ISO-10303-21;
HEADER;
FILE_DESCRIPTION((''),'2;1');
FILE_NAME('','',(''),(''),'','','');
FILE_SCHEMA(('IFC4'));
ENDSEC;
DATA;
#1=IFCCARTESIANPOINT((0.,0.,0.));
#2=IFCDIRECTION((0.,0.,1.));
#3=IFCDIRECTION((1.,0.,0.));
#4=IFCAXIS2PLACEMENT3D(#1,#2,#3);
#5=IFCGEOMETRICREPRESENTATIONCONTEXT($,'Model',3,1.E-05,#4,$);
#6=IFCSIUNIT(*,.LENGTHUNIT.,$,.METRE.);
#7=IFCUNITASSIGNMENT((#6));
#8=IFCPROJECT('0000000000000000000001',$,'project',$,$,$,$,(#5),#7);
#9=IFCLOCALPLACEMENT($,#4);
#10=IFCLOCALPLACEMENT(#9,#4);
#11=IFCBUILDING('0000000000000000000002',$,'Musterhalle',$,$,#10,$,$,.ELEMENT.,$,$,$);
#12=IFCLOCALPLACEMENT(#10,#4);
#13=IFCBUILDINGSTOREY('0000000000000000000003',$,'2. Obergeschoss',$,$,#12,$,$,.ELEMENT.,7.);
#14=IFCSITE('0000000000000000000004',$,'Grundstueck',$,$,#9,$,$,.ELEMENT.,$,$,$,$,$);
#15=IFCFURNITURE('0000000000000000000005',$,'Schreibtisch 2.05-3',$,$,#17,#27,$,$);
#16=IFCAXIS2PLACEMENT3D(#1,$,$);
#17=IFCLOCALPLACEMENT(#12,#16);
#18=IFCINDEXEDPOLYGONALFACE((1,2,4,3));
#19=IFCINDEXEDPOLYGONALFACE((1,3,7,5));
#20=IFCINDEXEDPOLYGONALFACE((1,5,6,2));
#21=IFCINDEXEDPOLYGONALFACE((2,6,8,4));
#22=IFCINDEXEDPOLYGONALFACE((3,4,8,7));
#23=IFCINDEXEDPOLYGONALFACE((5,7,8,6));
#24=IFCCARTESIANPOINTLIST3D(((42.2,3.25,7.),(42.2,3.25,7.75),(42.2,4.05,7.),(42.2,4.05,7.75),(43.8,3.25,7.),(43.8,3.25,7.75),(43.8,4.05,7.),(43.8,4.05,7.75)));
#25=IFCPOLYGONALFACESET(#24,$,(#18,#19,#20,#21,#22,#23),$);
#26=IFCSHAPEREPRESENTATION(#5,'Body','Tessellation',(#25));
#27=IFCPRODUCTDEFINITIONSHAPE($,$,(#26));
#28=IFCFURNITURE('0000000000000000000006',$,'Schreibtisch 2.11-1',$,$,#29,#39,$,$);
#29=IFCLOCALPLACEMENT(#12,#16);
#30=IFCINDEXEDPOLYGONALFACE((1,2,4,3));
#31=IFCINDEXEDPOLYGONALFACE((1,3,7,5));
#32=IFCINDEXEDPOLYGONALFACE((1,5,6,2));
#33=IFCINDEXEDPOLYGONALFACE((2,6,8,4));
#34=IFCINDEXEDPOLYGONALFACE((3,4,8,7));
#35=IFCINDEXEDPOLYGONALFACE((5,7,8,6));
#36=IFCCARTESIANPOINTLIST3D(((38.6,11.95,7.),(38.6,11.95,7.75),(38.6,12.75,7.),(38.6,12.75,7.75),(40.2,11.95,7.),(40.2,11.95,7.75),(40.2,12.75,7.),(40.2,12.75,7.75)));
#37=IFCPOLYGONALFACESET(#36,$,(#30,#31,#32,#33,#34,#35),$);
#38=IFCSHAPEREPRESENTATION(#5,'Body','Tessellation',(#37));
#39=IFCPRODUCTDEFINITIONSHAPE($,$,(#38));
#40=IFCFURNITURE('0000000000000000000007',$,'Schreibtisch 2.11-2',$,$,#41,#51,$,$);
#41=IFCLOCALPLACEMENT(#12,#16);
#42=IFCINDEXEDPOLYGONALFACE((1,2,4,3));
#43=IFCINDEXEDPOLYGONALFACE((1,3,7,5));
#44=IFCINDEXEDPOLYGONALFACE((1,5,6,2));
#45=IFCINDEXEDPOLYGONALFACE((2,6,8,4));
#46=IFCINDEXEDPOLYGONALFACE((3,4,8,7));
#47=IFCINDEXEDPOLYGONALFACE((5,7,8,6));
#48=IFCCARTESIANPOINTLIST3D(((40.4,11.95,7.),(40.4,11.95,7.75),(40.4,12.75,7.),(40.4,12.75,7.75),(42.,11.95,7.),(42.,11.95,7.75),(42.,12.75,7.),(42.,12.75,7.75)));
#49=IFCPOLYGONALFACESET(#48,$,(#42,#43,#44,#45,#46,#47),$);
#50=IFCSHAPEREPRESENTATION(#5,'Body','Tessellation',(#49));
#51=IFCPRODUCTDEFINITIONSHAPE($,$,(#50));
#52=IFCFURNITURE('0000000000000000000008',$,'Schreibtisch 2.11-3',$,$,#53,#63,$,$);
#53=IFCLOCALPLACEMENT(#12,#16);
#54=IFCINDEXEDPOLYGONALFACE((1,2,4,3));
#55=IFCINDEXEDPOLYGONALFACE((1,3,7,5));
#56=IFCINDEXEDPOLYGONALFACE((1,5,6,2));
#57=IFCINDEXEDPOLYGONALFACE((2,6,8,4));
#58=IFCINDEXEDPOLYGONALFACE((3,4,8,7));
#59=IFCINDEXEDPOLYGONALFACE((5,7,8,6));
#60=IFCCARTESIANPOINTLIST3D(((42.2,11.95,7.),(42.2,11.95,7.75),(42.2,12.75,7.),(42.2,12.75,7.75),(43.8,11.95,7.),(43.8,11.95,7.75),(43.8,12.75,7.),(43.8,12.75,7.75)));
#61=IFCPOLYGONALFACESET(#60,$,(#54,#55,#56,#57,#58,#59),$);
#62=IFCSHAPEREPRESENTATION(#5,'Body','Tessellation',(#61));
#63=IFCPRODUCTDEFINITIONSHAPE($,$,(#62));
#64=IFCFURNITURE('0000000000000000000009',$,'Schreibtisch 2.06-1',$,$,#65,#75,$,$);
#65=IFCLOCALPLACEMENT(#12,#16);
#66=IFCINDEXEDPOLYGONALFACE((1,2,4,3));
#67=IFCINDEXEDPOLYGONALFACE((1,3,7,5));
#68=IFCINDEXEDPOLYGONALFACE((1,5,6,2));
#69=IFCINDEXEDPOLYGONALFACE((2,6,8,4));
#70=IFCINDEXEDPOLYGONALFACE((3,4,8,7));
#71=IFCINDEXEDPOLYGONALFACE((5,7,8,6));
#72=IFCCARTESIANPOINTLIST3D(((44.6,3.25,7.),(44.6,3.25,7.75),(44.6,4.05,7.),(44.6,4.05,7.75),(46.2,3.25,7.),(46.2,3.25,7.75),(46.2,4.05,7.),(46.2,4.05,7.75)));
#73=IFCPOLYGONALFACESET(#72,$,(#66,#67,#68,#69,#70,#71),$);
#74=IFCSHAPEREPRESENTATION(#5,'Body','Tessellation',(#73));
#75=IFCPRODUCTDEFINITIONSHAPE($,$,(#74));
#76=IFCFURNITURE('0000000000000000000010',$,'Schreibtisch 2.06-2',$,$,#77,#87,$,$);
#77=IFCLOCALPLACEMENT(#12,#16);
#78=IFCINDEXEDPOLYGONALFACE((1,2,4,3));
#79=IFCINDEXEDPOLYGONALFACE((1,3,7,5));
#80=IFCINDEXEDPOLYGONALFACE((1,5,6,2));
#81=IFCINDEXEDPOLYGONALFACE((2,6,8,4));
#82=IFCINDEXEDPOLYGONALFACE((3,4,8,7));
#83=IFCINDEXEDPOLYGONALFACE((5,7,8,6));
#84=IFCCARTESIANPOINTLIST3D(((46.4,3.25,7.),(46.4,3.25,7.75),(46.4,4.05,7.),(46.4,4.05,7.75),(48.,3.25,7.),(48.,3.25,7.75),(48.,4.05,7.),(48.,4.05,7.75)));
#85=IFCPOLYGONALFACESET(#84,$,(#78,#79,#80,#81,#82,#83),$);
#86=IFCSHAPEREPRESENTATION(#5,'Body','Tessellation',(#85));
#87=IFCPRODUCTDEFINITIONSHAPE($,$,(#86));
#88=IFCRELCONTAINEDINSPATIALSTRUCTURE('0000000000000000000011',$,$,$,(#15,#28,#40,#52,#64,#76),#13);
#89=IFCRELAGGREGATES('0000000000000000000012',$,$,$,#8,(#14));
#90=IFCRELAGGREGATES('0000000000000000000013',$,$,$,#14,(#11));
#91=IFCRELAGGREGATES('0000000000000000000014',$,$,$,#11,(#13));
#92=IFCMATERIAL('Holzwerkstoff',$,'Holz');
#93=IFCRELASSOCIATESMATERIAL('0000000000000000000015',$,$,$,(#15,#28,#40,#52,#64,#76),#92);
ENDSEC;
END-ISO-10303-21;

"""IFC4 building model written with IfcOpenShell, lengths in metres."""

from ifc_helpers import new_model, si_unit, frame, origin_with_axes, origin_2d, place, context, project, spatial, rectangle, extrude, material, element, save


model = new_model("IFC4")

# Units and contexts
model_context = context("Model", 3, precision=1e-05, world=origin_with_axes())
ifc_project = project(units=[si_unit("LENGTHUNIT", "METRE")], contexts=[model_context])

# Site, building, storey
site_placement = place(None, origin_with_axes())
site = spatial("IfcSite", under=ifc_project, at=site_placement, Name="Grundstueck", CompositionType="ELEMENT")
building_placement = place(site_placement, origin_with_axes())
building = spatial("IfcBuilding", under=site, at=building_placement, Name="Musterhalle", CompositionType="ELEMENT")
storey_placement = place(building_placement, origin_with_axes())
storey = spatial("IfcBuildingStorey", under=building, at=storey_placement, Name="2. Obergeschoss", CompositionType="ELEMENT", Elevation=7.0)

# Shared definitions
placement = place(storey_placement, origin_with_axes())

# Shared definitions
ifc_material_1 = material(Name="Holzwerkstoff", Category="Holz")

# Furniture
element("IfcFurniture", 1, at=placement, inside=storey, material=ifc_material_1, Name="Schreibtisch 2.05-3", context=model_context, shape_type="SweptSolid", body=[
    extrude(rectangle(XDim=1.6, YDim=0.8, at=origin_2d()), frame((43.0, 3.65, 7.0), z_axis=(0.0, 0.0, 1.0), x_axis=(1.0, 0.0, 0.0)), (0.0, 0.0, 1.0), 0.75),
])
element("IfcFurniture", 2, at=placement, inside=storey, material=ifc_material_1, Name="Schreibtisch 2.11-1", context=model_context, shape_type="SweptSolid", body=[
    extrude(rectangle(XDim=1.6, YDim=0.8, at=origin_2d()), frame((39.4, 12.35, 7.0), z_axis=(0.0, 0.0, 1.0), x_axis=(1.0, 0.0, 0.0)), (0.0, 0.0, 1.0), 0.75),
])
element("IfcFurniture", 3, at=placement, inside=storey, material=ifc_material_1, Name="Schreibtisch 2.11-2", context=model_context, shape_type="SweptSolid", body=[
    extrude(rectangle(XDim=1.6, YDim=0.8, at=origin_2d()), frame((41.2, 12.35, 7.0), z_axis=(0.0, 0.0, 1.0), x_axis=(1.0, 0.0, 0.0)), (0.0, 0.0, 1.0), 0.75),
])
element("IfcFurniture", 4, at=placement, inside=storey, material=ifc_material_1, Name="Schreibtisch 2.11-3", context=model_context, shape_type="SweptSolid", body=[
    extrude(rectangle(XDim=1.6, YDim=0.8, at=origin_2d()), frame((43.0, 12.35, 7.0), z_axis=(0.0, 0.0, 1.0), x_axis=(1.0, 0.0, 0.0)), (0.0, 0.0, 1.0), 0.75),
])
element("IfcFurniture", 5, at=placement, inside=storey, material=ifc_material_1, Name="Schreibtisch 2.06-1", context=model_context, shape_type="SweptSolid", body=[
    extrude(rectangle(XDim=1.6, YDim=0.8, at=origin_2d()), frame((45.4, 3.65, 7.0), z_axis=(0.0, 0.0, 1.0), x_axis=(1.0, 0.0, 0.0)), (0.0, 0.0, 1.0), 0.75),
])
element("IfcFurniture", 6, at=placement, inside=storey, material=ifc_material_1, Name="Schreibtisch 2.06-2", context=model_context, shape_type="SweptSolid", body=[
    extrude(rectangle(XDim=1.6, YDim=0.8, at=origin_2d()), frame((47.2, 3.65, 7.0), z_axis=(0.0, 0.0, 1.0), x_axis=(1.0, 0.0, 0.0)), (0.0, 0.0, 1.0), 0.75),
])

save(model, "model.ifc")
